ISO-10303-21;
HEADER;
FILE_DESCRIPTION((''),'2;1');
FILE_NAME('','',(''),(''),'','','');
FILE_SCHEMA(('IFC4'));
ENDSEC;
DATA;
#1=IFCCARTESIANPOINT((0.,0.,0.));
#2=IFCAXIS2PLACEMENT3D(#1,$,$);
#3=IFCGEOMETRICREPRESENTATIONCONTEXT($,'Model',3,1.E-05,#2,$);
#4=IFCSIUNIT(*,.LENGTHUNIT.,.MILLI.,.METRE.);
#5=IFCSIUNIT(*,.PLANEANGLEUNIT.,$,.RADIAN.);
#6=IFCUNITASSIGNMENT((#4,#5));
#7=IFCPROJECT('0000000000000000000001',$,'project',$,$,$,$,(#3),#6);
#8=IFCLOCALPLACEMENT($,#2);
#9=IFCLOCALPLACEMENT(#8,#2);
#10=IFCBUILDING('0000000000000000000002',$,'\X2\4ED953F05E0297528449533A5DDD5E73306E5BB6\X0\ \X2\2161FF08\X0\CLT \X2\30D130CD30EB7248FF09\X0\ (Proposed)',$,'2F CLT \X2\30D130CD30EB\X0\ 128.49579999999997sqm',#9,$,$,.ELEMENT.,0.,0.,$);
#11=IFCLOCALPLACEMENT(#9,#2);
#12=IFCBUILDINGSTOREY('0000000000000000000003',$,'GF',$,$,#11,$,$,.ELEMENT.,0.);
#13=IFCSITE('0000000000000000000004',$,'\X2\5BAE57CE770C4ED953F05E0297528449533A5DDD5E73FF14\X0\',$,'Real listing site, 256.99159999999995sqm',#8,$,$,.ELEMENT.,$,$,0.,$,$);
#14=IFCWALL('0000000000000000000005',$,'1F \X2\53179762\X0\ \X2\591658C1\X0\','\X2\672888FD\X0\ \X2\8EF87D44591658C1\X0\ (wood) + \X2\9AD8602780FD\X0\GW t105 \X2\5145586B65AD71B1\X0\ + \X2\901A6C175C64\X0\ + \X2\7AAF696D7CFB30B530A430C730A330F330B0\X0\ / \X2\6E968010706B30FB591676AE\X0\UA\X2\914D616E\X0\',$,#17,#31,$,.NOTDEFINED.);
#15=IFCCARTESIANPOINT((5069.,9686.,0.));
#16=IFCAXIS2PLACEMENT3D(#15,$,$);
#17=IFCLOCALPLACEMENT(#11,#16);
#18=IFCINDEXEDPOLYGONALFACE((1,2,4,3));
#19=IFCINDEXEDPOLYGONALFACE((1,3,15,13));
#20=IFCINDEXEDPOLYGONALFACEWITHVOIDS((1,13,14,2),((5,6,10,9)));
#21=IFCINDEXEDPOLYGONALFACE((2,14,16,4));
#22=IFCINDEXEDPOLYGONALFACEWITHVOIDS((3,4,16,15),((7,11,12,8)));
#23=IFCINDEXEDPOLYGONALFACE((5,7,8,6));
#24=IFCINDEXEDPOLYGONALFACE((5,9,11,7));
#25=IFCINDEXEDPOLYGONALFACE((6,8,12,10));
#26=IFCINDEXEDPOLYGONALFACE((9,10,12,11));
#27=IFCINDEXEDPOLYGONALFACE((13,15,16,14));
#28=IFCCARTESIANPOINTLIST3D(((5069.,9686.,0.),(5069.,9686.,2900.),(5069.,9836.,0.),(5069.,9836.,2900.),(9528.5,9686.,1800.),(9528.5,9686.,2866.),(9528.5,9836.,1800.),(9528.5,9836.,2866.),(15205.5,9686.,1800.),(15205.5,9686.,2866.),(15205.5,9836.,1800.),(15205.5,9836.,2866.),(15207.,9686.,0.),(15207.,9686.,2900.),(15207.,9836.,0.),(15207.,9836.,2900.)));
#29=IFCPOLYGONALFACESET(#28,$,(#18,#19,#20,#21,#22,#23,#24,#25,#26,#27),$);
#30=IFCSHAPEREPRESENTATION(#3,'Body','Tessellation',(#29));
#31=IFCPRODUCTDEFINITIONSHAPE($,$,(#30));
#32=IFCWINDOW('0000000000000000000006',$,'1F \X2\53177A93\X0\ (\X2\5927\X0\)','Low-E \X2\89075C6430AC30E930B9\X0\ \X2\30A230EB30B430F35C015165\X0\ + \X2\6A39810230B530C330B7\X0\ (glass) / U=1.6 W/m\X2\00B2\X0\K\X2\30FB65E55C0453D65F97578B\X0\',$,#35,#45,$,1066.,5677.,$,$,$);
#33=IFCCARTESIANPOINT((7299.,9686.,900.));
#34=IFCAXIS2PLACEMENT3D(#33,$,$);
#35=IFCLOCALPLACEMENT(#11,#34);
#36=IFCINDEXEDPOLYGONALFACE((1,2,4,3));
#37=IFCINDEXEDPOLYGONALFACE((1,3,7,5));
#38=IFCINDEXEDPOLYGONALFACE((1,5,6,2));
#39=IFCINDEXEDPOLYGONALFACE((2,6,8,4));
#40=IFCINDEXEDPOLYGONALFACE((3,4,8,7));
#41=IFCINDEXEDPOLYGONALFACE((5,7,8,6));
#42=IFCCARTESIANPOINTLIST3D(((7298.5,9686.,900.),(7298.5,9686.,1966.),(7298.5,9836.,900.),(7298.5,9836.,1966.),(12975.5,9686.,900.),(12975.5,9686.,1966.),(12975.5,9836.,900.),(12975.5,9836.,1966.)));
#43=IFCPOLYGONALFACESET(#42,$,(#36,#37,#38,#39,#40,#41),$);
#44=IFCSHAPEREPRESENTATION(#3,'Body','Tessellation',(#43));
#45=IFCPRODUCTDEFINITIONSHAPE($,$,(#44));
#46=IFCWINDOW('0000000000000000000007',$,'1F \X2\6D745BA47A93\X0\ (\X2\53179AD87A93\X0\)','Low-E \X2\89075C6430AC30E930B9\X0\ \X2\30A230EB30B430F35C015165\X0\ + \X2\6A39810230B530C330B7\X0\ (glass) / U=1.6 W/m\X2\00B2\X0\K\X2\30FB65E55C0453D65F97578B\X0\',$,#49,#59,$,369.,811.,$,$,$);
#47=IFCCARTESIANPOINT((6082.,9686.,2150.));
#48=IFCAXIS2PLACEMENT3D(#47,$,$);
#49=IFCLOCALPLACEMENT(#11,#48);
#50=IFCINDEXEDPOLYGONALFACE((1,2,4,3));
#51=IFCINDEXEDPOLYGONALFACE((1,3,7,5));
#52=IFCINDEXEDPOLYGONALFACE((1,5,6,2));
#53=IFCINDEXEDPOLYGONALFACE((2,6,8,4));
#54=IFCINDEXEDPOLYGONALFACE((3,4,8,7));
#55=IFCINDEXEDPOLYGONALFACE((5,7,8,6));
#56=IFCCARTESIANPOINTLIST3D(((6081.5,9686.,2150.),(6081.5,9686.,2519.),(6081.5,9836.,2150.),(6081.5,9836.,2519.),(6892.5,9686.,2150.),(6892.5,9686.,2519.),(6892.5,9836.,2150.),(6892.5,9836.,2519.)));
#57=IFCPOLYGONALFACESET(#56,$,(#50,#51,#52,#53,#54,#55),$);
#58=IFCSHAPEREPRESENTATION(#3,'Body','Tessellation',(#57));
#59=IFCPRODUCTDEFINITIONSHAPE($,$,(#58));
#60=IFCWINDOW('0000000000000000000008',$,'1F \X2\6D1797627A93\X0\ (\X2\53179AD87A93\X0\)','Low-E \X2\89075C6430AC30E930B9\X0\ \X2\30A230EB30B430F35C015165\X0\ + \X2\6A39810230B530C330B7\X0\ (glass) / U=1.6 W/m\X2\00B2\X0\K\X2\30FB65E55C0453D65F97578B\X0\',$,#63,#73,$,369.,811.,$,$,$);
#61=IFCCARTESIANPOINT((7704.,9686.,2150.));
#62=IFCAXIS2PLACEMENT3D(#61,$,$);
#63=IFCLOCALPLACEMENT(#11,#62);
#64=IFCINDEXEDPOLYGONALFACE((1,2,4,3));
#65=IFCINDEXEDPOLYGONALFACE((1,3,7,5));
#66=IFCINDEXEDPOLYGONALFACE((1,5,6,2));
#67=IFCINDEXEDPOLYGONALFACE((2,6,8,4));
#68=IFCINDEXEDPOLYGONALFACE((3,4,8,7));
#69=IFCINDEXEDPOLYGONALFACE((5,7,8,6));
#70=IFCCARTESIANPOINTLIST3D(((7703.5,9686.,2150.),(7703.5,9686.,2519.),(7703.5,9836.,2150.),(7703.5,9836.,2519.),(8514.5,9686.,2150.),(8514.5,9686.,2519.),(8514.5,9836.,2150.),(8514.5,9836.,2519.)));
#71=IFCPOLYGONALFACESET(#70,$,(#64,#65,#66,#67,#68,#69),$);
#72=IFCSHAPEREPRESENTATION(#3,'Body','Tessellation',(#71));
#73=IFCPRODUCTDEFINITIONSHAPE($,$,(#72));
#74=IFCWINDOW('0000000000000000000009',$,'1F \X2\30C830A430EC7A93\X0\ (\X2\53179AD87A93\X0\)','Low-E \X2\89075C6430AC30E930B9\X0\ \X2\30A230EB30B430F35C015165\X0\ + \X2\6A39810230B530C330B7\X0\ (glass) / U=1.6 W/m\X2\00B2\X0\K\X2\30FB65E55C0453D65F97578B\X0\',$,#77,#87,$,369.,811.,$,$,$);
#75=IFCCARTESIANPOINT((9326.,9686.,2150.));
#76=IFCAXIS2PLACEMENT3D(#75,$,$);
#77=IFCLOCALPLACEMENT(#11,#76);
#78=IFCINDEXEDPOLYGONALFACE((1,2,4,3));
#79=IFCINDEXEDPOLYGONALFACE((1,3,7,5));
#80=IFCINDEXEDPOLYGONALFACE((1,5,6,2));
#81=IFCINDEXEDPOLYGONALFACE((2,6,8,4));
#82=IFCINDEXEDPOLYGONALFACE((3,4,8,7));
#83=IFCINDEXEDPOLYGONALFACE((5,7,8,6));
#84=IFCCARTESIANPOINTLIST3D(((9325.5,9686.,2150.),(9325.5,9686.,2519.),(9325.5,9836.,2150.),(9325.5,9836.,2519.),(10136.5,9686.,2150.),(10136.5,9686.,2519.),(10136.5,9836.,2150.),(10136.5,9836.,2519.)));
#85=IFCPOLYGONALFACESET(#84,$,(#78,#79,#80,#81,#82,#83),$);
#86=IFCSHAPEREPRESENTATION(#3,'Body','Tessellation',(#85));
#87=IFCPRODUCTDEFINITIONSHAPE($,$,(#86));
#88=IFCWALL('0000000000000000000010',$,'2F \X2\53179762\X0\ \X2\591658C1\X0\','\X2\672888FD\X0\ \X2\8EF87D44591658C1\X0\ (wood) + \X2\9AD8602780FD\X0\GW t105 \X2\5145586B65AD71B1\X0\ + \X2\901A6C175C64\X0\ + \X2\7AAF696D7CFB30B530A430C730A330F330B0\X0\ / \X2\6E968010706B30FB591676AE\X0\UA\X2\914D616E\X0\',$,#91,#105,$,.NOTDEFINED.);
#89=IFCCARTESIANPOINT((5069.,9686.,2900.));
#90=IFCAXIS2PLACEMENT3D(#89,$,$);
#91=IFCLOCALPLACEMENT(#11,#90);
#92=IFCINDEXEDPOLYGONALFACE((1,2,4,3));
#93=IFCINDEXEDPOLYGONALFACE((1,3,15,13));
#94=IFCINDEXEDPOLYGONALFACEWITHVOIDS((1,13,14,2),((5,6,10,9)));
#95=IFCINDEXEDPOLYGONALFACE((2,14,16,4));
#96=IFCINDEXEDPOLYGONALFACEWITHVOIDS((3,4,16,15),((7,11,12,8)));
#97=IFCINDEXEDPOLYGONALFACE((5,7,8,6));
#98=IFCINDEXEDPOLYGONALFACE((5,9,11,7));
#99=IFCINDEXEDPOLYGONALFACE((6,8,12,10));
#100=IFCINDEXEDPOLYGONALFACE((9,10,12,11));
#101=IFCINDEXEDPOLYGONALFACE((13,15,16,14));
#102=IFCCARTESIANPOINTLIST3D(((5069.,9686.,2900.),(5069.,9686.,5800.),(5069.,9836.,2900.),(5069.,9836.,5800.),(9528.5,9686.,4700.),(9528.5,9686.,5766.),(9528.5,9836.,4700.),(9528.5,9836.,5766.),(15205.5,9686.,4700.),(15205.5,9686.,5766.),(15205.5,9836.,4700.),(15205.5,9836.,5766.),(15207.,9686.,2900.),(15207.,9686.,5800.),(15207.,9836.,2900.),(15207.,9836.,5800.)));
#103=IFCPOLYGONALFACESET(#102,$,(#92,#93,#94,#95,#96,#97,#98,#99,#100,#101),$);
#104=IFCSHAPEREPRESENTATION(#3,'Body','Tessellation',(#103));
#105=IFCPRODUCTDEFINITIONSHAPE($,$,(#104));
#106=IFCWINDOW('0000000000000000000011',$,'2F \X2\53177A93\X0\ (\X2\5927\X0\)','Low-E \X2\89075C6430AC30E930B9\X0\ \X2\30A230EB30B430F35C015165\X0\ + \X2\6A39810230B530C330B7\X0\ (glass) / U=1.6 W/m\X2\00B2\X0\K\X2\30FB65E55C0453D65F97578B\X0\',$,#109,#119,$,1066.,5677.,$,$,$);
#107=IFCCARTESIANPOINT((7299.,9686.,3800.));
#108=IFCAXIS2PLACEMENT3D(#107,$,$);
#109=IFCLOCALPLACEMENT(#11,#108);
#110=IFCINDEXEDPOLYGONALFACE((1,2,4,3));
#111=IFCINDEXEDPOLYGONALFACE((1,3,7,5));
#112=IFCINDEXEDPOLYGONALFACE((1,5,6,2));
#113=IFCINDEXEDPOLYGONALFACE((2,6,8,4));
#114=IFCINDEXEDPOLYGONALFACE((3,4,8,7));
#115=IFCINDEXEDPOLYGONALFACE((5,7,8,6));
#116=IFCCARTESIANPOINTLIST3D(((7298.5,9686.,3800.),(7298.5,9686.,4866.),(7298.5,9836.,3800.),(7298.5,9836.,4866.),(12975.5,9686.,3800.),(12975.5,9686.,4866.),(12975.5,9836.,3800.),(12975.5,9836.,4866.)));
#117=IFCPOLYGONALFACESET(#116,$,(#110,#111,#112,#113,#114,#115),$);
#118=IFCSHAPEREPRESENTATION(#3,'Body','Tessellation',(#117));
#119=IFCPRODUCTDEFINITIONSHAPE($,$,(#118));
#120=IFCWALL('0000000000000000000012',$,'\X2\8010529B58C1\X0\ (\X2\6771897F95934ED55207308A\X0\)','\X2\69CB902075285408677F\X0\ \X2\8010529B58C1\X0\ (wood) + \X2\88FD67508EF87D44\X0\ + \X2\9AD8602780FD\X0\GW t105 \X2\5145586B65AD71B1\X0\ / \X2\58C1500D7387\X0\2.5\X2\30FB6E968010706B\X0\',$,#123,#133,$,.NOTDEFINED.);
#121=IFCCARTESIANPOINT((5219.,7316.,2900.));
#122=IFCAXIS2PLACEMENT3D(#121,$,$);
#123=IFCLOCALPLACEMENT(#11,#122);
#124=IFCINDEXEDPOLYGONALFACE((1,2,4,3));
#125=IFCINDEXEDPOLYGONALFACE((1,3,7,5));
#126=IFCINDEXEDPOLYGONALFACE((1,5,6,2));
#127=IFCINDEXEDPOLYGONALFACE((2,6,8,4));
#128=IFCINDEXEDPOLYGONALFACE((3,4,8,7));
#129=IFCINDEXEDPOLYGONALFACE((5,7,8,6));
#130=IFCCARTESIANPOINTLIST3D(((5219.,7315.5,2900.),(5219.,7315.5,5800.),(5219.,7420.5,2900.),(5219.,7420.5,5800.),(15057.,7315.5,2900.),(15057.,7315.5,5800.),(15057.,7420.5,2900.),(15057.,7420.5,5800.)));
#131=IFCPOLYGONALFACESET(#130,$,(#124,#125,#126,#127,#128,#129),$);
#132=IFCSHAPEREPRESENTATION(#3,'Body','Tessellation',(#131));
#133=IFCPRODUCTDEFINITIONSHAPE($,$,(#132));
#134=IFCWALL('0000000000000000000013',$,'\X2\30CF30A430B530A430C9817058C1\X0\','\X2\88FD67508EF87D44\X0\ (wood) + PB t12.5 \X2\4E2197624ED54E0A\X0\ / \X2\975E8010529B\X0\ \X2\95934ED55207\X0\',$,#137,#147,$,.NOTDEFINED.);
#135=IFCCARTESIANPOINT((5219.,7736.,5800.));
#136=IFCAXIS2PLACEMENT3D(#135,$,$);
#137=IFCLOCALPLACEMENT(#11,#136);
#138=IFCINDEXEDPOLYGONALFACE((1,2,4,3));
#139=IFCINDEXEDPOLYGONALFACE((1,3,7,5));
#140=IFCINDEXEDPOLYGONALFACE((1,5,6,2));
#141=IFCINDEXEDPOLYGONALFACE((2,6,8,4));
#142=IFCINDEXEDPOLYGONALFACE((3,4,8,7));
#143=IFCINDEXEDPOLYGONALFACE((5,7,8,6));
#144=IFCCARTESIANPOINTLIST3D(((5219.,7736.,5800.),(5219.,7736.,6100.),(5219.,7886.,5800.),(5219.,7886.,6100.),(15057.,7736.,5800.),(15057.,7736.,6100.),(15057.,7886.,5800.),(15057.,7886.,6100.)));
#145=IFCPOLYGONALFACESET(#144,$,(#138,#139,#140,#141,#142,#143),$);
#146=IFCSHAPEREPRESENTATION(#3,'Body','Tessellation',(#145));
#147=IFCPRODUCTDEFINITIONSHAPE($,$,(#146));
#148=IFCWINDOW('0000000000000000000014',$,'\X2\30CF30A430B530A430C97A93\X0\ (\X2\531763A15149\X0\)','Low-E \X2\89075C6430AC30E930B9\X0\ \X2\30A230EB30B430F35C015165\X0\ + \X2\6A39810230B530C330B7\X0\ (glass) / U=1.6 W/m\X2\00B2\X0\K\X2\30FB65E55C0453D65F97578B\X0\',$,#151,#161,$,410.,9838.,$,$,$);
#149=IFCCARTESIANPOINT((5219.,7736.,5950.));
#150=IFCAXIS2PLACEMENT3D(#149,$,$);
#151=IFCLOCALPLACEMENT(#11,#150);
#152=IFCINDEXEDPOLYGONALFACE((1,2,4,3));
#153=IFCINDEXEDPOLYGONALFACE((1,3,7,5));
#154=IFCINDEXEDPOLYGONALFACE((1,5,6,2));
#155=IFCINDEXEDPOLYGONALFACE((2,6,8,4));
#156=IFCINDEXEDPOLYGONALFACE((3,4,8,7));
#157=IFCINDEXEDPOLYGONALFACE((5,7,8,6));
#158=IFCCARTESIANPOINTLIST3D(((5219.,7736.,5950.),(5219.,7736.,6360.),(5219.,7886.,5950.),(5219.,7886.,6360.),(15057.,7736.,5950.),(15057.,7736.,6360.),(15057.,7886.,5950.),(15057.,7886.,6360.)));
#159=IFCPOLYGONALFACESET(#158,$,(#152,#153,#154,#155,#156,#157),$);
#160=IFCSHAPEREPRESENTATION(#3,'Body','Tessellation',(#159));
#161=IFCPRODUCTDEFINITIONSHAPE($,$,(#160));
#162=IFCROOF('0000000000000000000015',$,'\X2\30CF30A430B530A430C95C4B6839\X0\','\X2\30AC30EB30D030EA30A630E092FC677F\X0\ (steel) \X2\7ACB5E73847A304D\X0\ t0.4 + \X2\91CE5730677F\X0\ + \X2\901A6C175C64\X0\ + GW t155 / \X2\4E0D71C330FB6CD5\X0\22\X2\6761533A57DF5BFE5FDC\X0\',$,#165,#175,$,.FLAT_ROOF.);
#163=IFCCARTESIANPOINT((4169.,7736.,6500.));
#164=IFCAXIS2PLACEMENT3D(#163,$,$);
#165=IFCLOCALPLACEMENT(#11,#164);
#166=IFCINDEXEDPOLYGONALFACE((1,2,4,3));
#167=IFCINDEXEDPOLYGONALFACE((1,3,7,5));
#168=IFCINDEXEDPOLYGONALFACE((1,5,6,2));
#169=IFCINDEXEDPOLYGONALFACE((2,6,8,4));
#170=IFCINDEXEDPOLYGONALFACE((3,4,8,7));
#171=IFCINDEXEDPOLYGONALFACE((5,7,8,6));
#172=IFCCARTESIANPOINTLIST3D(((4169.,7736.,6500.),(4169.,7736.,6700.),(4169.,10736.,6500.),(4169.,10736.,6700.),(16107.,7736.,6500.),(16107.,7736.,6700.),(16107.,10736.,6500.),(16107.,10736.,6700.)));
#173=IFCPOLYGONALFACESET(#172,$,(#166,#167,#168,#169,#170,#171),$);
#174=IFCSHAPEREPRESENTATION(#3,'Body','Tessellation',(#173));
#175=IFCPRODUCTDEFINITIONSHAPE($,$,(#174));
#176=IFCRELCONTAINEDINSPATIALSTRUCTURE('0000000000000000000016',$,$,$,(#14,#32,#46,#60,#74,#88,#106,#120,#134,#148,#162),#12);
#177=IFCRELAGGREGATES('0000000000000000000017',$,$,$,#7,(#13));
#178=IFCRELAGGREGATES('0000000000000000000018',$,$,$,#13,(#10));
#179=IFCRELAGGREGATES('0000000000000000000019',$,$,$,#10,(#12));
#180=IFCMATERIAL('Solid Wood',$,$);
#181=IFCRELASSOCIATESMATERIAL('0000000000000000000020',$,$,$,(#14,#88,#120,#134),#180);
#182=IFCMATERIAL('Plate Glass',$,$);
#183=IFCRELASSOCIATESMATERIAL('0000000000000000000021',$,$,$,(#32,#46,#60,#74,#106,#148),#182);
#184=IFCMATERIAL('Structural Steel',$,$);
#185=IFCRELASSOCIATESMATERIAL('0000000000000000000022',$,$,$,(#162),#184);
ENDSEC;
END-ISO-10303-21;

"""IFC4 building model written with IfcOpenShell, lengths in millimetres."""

from ifc_helpers import new_model, si_unit, frame, frame_2d, origin, place, context, project, spatial, rectangle, extrude, material, element, fill, save


model = new_model("IFC4")

# Units and contexts
model_context = context("Model", 3, precision=1e-05, world=origin())
ifc_project = project(units=[si_unit("LENGTHUNIT", "METRE", prefix="MILLI"), si_unit("PLANEANGLEUNIT", "RADIAN")], contexts=[model_context])

# Site, building, storey
site_placement = place(None, origin())
site = spatial("IfcSite", under=ifc_project, at=site_placement, Name="宮城県仙台市青葉区川平４", ObjectType="Real listing site, 256.99159999999995sqm", CompositionType="ELEMENT", RefElevation=0.0)
building_placement = place(site_placement, origin())
building = spatial("IfcBuilding", under=site, at=building_placement, Name="仙台市青葉区川平の家 Ⅱ（CLT パネル版） (Proposed)", ObjectType="2F CLT パネル 128.49579999999997sqm", CompositionType="ELEMENT", ElevationOfRefHeight=0.0, ElevationOfTerrain=0.0)
storey_placement = place(building_placement, origin())
storey = spatial("IfcBuildingStorey", under=building, at=storey_placement, Name="GF", CompositionType="ELEMENT", Elevation=0.0)

# Wall, openings, windows
ifc_material_1 = material(Name="Solid Wood")
wall_1_placement = place(storey_placement, frame((5069.0, 9686.0, 0.0)))
wall_1 = element("IfcWall", 1, at=wall_1_placement, inside=storey, material=ifc_material_1, Name="1F 北面 外壁", Description="木製 軸組外壁 (wood) + 高性能GW t105 充填断熱 + 通気層 + 窯業系サイディング / 準耐火・外皮UA配慮", PredefinedType="NOTDEFINED", context=model_context, shape_type="SweptSolid", body=[
    extrude(rectangle(XDim=10138.0, YDim=150.0, at=frame_2d((5069.0, 75.0))), frame((5069.0, 9686.0, 0.0)), (0.0, 0.0, 1.0), 2900.0),
])
opening_1_placement = place(storey_placement, frame((7299.0, 9686.0, 900.0)))
opening_1 = element("IfcOpeningElement", 2, at=opening_1_placement, cuts=wall_1, PredefinedType="NOTDEFINED", context=model_context, shape_type="SweptSolid", body=[
    extrude(rectangle(XDim=5677.0, YDim=150.0, at=frame_2d((2838.0, 75.0))), frame((7299.0, 9686.0, 900.0)), (0.0, 0.0, 1.0), 1066.0),
])
opening_2_placement = place(storey_placement, frame((6082.0, 9686.0, 2150.0)))
opening_2 = element("IfcOpeningElement", 3, at=opening_2_placement, cuts=wall_1, PredefinedType="NOTDEFINED", context=model_context, shape_type="SweptSolid", body=[
    extrude(rectangle(XDim=811.0, YDim=150.0, at=frame_2d((405.0, 75.0))), frame((6082.0, 9686.0, 2150.0)), (0.0, 0.0, 1.0), 369.0),
])
opening_3_placement = place(storey_placement, frame((7704.0, 9686.0, 2150.0)))
opening_3 = element("IfcOpeningElement", 4, at=opening_3_placement, cuts=wall_1, PredefinedType="NOTDEFINED", context=model_context, shape_type="SweptSolid", body=[
    extrude(rectangle(XDim=811.0, YDim=150.0, at=frame_2d((405.0, 75.0))), frame((7704.0, 9686.0, 2150.0)), (0.0, 0.0, 1.0), 369.0),
])
opening_4_placement = place(storey_placement, frame((9326.0, 9686.0, 2150.0)))
opening_4 = element("IfcOpeningElement", 5, at=opening_4_placement, cuts=wall_1, PredefinedType="NOTDEFINED", context=model_context, shape_type="SweptSolid", body=[
    extrude(rectangle(XDim=811.0, YDim=150.0, at=frame_2d((405.0, 75.0))), frame((9326.0, 9686.0, 2150.0)), (0.0, 0.0, 1.0), 369.0),
])
ifc_material_2 = material(Name="Plate Glass")
window_1_placement = place(storey_placement, frame((7299.0, 9686.0, 900.0)))
window_1 = element("IfcWindow", 6, at=window_1_placement, inside=storey, material=ifc_material_2, Name="1F 北窓 (大)", Description="Low-E 複層ガラス アルゴン封入 + 樹脂サッシ (glass) / U=1.6 W/m²K・日射取得型", OverallHeight=1066.0, OverallWidth=5677.0, context=model_context, shape_type="SweptSolid", body=[
    extrude(rectangle(XDim=5677.0, YDim=150.0, at=frame_2d((2838.0, 75.0))), frame((7299.0, 9686.0, 900.0)), (0.0, 0.0, 1.0), 1066.0),
])
fill(opening_1, window_1)
window_2_placement = place(storey_placement, frame((6082.0, 9686.0, 2150.0)))
window_2 = element("IfcWindow", 7, at=window_2_placement, inside=storey, material=ifc_material_2, Name="1F 浴室窓 (北高窓)", Description="Low-E 複層ガラス アルゴン封入 + 樹脂サッシ (glass) / U=1.6 W/m²K・日射取得型", OverallHeight=369.0, OverallWidth=811.0, context=model_context, shape_type="SweptSolid", body=[
    extrude(rectangle(XDim=811.0, YDim=150.0, at=frame_2d((405.0, 75.0))), frame((6082.0, 9686.0, 2150.0)), (0.0, 0.0, 1.0), 369.0),
])
fill(opening_2, window_2)
window_3_placement = place(storey_placement, frame((7704.0, 9686.0, 2150.0)))
window_3 = element("IfcWindow", 8, at=window_3_placement, inside=storey, material=ifc_material_2, Name="1F 洗面窓 (北高窓)", Description="Low-E 複層ガラス アルゴン封入 + 樹脂サッシ (glass) / U=1.6 W/m²K・日射取得型", OverallHeight=369.0, OverallWidth=811.0, context=model_context, shape_type="SweptSolid", body=[
    extrude(rectangle(XDim=811.0, YDim=150.0, at=frame_2d((405.0, 75.0))), frame((7704.0, 9686.0, 2150.0)), (0.0, 0.0, 1.0), 369.0),
])
fill(opening_3, window_3)
window_4_placement = place(storey_placement, frame((9326.0, 9686.0, 2150.0)))
window_4 = element("IfcWindow", 9, at=window_4_placement, inside=storey, material=ifc_material_2, Name="1F トイレ窓 (北高窓)", Description="Low-E 複層ガラス アルゴン封入 + 樹脂サッシ (glass) / U=1.6 W/m²K・日射取得型", OverallHeight=369.0, OverallWidth=811.0, context=model_context, shape_type="SweptSolid", body=[
    extrude(rectangle(XDim=811.0, YDim=150.0, at=frame_2d((405.0, 75.0))), frame((9326.0, 9686.0, 2150.0)), (0.0, 0.0, 1.0), 369.0),
])
fill(opening_4, window_4)

# Wall, opening, window
wall_2_placement = place(storey_placement, frame((5069.0, 9686.0, 2900.0)))
wall_2 = element("IfcWall", 10, at=wall_2_placement, inside=storey, material=ifc_material_1, Name="2F 北面 外壁", Description="木製 軸組外壁 (wood) + 高性能GW t105 充填断熱 + 通気層 + 窯業系サイディング / 準耐火・外皮UA配慮", PredefinedType="NOTDEFINED", context=model_context, shape_type="SweptSolid", body=[
    extrude(rectangle(XDim=10138.0, YDim=150.0, at=frame_2d((5069.0, 75.0))), frame((5069.0, 9686.0, 2900.0)), (0.0, 0.0, 1.0), 2900.0),
])
opening_5_placement = place(storey_placement, frame((7299.0, 9686.0, 3800.0)))
opening_5 = element("IfcOpeningElement", 11, at=opening_5_placement, cuts=wall_2, PredefinedType="NOTDEFINED", context=model_context, shape_type="SweptSolid", body=[
    extrude(rectangle(XDim=5677.0, YDim=150.0, at=frame_2d((2838.0, 75.0))), frame((7299.0, 9686.0, 3800.0)), (0.0, 0.0, 1.0), 1066.0),
])
window_5_placement = place(storey_placement, frame((7299.0, 9686.0, 3800.0)))
window_5 = element("IfcWindow", 12, at=window_5_placement, inside=storey, material=ifc_material_2, Name="2F 北窓 (大)", Description="Low-E 複層ガラス アルゴン封入 + 樹脂サッシ (glass) / U=1.6 W/m²K・日射取得型", OverallHeight=1066.0, OverallWidth=5677.0, context=model_context, shape_type="SweptSolid", body=[
    extrude(rectangle(XDim=5677.0, YDim=150.0, at=frame_2d((2838.0, 75.0))), frame((7299.0, 9686.0, 3800.0)), (0.0, 0.0, 1.0), 1066.0),
])
fill(opening_5, window_5)

# Wall
wall_3_placement = place(storey_placement, frame((5219.0, 7316.0, 2900.0)))
element("IfcWall", 13, at=wall_3_placement, inside=storey, material=ifc_material_1, Name="耐力壁 (東西間仕切り)", Description="構造用合板 耐力壁 (wood) + 製材軸組 + 高性能GW t105 充填断熱 / 壁倍率2.5・準耐火", PredefinedType="NOTDEFINED", context=model_context, shape_type="SweptSolid", body=[
    extrude(rectangle(XDim=9838.0, YDim=105.0, at=frame_2d((4919.0, 52.0))), frame((5219.0, 7316.0, 2900.0)), (0.0, 0.0, 1.0), 2900.0),
])

# Wall, opening, window
wall_4_placement = place(storey_placement, frame((5219.0, 7736.0, 5800.0)))
wall_4 = element("IfcWall", 14, at=wall_4_placement, inside=storey, material=ifc_material_1, Name="ハイサイド腰壁", Description="製材軸組 (wood) + PB t12.5 両面仕上 / 非耐力 間仕切", PredefinedType="NOTDEFINED", context=model_context, shape_type="SweptSolid", body=[
    extrude(rectangle(XDim=9838.0, YDim=150.0, at=frame_2d((4919.0, 75.0))), frame((5219.0, 7736.0, 5800.0)), (0.0, 0.0, 1.0), 700.0),
])
opening_6_placement = place(storey_placement, frame((5219.0, 7736.0, 5950.0)))
opening_6 = element("IfcOpeningElement", 15, at=opening_6_placement, cuts=wall_4, PredefinedType="NOTDEFINED", context=model_context, shape_type="SweptSolid", body=[
    extrude(rectangle(XDim=9838.0, YDim=150.0, at=frame_2d((4919.0, 75.0))), frame((5219.0, 7736.0, 5950.0)), (0.0, 0.0, 1.0), 410.0),
])
window_6_placement = place(storey_placement, frame((5219.0, 7736.0, 5950.0)))
window_6 = element("IfcWindow", 16, at=window_6_placement, inside=storey, material=ifc_material_2, Name="ハイサイド窓 (北採光)", Description="Low-E 複層ガラス アルゴン封入 + 樹脂サッシ (glass) / U=1.6 W/m²K・日射取得型", OverallHeight=410.0, OverallWidth=9838.0, context=model_context, shape_type="SweptSolid", body=[
    extrude(rectangle(XDim=9838.0, YDim=150.0, at=frame_2d((4919.0, 75.0))), frame((5219.0, 7736.0, 5950.0)), (0.0, 0.0, 1.0), 410.0),
])
fill(opening_6, window_6)

# Roof
ifc_material_3 = material(Name="Structural Steel")
roof_placement = place(storey_placement, frame((4169.0, 7736.0, 6500.0)))
element("IfcRoof", 17, at=roof_placement, inside=storey, material=ifc_material_3, Name="ハイサイド屋根", Description="ガルバリウム鋼板 (steel) 立平葺き t0.4 + 野地板 + 通気層 + GW t155 / 不燃・法22条区域対応", PredefinedType="FLAT_ROOF", context=model_context, shape_type="SweptSolid", body=[
    extrude(rectangle(XDim=11938.0, YDim=3000.0, at=frame_2d((5969.0, 1500.0))), frame((4169.0, 7736.0, 6500.0)), (0.0, 0.0, 1.0), 200.0),
])

save(model, "model.ifc")
